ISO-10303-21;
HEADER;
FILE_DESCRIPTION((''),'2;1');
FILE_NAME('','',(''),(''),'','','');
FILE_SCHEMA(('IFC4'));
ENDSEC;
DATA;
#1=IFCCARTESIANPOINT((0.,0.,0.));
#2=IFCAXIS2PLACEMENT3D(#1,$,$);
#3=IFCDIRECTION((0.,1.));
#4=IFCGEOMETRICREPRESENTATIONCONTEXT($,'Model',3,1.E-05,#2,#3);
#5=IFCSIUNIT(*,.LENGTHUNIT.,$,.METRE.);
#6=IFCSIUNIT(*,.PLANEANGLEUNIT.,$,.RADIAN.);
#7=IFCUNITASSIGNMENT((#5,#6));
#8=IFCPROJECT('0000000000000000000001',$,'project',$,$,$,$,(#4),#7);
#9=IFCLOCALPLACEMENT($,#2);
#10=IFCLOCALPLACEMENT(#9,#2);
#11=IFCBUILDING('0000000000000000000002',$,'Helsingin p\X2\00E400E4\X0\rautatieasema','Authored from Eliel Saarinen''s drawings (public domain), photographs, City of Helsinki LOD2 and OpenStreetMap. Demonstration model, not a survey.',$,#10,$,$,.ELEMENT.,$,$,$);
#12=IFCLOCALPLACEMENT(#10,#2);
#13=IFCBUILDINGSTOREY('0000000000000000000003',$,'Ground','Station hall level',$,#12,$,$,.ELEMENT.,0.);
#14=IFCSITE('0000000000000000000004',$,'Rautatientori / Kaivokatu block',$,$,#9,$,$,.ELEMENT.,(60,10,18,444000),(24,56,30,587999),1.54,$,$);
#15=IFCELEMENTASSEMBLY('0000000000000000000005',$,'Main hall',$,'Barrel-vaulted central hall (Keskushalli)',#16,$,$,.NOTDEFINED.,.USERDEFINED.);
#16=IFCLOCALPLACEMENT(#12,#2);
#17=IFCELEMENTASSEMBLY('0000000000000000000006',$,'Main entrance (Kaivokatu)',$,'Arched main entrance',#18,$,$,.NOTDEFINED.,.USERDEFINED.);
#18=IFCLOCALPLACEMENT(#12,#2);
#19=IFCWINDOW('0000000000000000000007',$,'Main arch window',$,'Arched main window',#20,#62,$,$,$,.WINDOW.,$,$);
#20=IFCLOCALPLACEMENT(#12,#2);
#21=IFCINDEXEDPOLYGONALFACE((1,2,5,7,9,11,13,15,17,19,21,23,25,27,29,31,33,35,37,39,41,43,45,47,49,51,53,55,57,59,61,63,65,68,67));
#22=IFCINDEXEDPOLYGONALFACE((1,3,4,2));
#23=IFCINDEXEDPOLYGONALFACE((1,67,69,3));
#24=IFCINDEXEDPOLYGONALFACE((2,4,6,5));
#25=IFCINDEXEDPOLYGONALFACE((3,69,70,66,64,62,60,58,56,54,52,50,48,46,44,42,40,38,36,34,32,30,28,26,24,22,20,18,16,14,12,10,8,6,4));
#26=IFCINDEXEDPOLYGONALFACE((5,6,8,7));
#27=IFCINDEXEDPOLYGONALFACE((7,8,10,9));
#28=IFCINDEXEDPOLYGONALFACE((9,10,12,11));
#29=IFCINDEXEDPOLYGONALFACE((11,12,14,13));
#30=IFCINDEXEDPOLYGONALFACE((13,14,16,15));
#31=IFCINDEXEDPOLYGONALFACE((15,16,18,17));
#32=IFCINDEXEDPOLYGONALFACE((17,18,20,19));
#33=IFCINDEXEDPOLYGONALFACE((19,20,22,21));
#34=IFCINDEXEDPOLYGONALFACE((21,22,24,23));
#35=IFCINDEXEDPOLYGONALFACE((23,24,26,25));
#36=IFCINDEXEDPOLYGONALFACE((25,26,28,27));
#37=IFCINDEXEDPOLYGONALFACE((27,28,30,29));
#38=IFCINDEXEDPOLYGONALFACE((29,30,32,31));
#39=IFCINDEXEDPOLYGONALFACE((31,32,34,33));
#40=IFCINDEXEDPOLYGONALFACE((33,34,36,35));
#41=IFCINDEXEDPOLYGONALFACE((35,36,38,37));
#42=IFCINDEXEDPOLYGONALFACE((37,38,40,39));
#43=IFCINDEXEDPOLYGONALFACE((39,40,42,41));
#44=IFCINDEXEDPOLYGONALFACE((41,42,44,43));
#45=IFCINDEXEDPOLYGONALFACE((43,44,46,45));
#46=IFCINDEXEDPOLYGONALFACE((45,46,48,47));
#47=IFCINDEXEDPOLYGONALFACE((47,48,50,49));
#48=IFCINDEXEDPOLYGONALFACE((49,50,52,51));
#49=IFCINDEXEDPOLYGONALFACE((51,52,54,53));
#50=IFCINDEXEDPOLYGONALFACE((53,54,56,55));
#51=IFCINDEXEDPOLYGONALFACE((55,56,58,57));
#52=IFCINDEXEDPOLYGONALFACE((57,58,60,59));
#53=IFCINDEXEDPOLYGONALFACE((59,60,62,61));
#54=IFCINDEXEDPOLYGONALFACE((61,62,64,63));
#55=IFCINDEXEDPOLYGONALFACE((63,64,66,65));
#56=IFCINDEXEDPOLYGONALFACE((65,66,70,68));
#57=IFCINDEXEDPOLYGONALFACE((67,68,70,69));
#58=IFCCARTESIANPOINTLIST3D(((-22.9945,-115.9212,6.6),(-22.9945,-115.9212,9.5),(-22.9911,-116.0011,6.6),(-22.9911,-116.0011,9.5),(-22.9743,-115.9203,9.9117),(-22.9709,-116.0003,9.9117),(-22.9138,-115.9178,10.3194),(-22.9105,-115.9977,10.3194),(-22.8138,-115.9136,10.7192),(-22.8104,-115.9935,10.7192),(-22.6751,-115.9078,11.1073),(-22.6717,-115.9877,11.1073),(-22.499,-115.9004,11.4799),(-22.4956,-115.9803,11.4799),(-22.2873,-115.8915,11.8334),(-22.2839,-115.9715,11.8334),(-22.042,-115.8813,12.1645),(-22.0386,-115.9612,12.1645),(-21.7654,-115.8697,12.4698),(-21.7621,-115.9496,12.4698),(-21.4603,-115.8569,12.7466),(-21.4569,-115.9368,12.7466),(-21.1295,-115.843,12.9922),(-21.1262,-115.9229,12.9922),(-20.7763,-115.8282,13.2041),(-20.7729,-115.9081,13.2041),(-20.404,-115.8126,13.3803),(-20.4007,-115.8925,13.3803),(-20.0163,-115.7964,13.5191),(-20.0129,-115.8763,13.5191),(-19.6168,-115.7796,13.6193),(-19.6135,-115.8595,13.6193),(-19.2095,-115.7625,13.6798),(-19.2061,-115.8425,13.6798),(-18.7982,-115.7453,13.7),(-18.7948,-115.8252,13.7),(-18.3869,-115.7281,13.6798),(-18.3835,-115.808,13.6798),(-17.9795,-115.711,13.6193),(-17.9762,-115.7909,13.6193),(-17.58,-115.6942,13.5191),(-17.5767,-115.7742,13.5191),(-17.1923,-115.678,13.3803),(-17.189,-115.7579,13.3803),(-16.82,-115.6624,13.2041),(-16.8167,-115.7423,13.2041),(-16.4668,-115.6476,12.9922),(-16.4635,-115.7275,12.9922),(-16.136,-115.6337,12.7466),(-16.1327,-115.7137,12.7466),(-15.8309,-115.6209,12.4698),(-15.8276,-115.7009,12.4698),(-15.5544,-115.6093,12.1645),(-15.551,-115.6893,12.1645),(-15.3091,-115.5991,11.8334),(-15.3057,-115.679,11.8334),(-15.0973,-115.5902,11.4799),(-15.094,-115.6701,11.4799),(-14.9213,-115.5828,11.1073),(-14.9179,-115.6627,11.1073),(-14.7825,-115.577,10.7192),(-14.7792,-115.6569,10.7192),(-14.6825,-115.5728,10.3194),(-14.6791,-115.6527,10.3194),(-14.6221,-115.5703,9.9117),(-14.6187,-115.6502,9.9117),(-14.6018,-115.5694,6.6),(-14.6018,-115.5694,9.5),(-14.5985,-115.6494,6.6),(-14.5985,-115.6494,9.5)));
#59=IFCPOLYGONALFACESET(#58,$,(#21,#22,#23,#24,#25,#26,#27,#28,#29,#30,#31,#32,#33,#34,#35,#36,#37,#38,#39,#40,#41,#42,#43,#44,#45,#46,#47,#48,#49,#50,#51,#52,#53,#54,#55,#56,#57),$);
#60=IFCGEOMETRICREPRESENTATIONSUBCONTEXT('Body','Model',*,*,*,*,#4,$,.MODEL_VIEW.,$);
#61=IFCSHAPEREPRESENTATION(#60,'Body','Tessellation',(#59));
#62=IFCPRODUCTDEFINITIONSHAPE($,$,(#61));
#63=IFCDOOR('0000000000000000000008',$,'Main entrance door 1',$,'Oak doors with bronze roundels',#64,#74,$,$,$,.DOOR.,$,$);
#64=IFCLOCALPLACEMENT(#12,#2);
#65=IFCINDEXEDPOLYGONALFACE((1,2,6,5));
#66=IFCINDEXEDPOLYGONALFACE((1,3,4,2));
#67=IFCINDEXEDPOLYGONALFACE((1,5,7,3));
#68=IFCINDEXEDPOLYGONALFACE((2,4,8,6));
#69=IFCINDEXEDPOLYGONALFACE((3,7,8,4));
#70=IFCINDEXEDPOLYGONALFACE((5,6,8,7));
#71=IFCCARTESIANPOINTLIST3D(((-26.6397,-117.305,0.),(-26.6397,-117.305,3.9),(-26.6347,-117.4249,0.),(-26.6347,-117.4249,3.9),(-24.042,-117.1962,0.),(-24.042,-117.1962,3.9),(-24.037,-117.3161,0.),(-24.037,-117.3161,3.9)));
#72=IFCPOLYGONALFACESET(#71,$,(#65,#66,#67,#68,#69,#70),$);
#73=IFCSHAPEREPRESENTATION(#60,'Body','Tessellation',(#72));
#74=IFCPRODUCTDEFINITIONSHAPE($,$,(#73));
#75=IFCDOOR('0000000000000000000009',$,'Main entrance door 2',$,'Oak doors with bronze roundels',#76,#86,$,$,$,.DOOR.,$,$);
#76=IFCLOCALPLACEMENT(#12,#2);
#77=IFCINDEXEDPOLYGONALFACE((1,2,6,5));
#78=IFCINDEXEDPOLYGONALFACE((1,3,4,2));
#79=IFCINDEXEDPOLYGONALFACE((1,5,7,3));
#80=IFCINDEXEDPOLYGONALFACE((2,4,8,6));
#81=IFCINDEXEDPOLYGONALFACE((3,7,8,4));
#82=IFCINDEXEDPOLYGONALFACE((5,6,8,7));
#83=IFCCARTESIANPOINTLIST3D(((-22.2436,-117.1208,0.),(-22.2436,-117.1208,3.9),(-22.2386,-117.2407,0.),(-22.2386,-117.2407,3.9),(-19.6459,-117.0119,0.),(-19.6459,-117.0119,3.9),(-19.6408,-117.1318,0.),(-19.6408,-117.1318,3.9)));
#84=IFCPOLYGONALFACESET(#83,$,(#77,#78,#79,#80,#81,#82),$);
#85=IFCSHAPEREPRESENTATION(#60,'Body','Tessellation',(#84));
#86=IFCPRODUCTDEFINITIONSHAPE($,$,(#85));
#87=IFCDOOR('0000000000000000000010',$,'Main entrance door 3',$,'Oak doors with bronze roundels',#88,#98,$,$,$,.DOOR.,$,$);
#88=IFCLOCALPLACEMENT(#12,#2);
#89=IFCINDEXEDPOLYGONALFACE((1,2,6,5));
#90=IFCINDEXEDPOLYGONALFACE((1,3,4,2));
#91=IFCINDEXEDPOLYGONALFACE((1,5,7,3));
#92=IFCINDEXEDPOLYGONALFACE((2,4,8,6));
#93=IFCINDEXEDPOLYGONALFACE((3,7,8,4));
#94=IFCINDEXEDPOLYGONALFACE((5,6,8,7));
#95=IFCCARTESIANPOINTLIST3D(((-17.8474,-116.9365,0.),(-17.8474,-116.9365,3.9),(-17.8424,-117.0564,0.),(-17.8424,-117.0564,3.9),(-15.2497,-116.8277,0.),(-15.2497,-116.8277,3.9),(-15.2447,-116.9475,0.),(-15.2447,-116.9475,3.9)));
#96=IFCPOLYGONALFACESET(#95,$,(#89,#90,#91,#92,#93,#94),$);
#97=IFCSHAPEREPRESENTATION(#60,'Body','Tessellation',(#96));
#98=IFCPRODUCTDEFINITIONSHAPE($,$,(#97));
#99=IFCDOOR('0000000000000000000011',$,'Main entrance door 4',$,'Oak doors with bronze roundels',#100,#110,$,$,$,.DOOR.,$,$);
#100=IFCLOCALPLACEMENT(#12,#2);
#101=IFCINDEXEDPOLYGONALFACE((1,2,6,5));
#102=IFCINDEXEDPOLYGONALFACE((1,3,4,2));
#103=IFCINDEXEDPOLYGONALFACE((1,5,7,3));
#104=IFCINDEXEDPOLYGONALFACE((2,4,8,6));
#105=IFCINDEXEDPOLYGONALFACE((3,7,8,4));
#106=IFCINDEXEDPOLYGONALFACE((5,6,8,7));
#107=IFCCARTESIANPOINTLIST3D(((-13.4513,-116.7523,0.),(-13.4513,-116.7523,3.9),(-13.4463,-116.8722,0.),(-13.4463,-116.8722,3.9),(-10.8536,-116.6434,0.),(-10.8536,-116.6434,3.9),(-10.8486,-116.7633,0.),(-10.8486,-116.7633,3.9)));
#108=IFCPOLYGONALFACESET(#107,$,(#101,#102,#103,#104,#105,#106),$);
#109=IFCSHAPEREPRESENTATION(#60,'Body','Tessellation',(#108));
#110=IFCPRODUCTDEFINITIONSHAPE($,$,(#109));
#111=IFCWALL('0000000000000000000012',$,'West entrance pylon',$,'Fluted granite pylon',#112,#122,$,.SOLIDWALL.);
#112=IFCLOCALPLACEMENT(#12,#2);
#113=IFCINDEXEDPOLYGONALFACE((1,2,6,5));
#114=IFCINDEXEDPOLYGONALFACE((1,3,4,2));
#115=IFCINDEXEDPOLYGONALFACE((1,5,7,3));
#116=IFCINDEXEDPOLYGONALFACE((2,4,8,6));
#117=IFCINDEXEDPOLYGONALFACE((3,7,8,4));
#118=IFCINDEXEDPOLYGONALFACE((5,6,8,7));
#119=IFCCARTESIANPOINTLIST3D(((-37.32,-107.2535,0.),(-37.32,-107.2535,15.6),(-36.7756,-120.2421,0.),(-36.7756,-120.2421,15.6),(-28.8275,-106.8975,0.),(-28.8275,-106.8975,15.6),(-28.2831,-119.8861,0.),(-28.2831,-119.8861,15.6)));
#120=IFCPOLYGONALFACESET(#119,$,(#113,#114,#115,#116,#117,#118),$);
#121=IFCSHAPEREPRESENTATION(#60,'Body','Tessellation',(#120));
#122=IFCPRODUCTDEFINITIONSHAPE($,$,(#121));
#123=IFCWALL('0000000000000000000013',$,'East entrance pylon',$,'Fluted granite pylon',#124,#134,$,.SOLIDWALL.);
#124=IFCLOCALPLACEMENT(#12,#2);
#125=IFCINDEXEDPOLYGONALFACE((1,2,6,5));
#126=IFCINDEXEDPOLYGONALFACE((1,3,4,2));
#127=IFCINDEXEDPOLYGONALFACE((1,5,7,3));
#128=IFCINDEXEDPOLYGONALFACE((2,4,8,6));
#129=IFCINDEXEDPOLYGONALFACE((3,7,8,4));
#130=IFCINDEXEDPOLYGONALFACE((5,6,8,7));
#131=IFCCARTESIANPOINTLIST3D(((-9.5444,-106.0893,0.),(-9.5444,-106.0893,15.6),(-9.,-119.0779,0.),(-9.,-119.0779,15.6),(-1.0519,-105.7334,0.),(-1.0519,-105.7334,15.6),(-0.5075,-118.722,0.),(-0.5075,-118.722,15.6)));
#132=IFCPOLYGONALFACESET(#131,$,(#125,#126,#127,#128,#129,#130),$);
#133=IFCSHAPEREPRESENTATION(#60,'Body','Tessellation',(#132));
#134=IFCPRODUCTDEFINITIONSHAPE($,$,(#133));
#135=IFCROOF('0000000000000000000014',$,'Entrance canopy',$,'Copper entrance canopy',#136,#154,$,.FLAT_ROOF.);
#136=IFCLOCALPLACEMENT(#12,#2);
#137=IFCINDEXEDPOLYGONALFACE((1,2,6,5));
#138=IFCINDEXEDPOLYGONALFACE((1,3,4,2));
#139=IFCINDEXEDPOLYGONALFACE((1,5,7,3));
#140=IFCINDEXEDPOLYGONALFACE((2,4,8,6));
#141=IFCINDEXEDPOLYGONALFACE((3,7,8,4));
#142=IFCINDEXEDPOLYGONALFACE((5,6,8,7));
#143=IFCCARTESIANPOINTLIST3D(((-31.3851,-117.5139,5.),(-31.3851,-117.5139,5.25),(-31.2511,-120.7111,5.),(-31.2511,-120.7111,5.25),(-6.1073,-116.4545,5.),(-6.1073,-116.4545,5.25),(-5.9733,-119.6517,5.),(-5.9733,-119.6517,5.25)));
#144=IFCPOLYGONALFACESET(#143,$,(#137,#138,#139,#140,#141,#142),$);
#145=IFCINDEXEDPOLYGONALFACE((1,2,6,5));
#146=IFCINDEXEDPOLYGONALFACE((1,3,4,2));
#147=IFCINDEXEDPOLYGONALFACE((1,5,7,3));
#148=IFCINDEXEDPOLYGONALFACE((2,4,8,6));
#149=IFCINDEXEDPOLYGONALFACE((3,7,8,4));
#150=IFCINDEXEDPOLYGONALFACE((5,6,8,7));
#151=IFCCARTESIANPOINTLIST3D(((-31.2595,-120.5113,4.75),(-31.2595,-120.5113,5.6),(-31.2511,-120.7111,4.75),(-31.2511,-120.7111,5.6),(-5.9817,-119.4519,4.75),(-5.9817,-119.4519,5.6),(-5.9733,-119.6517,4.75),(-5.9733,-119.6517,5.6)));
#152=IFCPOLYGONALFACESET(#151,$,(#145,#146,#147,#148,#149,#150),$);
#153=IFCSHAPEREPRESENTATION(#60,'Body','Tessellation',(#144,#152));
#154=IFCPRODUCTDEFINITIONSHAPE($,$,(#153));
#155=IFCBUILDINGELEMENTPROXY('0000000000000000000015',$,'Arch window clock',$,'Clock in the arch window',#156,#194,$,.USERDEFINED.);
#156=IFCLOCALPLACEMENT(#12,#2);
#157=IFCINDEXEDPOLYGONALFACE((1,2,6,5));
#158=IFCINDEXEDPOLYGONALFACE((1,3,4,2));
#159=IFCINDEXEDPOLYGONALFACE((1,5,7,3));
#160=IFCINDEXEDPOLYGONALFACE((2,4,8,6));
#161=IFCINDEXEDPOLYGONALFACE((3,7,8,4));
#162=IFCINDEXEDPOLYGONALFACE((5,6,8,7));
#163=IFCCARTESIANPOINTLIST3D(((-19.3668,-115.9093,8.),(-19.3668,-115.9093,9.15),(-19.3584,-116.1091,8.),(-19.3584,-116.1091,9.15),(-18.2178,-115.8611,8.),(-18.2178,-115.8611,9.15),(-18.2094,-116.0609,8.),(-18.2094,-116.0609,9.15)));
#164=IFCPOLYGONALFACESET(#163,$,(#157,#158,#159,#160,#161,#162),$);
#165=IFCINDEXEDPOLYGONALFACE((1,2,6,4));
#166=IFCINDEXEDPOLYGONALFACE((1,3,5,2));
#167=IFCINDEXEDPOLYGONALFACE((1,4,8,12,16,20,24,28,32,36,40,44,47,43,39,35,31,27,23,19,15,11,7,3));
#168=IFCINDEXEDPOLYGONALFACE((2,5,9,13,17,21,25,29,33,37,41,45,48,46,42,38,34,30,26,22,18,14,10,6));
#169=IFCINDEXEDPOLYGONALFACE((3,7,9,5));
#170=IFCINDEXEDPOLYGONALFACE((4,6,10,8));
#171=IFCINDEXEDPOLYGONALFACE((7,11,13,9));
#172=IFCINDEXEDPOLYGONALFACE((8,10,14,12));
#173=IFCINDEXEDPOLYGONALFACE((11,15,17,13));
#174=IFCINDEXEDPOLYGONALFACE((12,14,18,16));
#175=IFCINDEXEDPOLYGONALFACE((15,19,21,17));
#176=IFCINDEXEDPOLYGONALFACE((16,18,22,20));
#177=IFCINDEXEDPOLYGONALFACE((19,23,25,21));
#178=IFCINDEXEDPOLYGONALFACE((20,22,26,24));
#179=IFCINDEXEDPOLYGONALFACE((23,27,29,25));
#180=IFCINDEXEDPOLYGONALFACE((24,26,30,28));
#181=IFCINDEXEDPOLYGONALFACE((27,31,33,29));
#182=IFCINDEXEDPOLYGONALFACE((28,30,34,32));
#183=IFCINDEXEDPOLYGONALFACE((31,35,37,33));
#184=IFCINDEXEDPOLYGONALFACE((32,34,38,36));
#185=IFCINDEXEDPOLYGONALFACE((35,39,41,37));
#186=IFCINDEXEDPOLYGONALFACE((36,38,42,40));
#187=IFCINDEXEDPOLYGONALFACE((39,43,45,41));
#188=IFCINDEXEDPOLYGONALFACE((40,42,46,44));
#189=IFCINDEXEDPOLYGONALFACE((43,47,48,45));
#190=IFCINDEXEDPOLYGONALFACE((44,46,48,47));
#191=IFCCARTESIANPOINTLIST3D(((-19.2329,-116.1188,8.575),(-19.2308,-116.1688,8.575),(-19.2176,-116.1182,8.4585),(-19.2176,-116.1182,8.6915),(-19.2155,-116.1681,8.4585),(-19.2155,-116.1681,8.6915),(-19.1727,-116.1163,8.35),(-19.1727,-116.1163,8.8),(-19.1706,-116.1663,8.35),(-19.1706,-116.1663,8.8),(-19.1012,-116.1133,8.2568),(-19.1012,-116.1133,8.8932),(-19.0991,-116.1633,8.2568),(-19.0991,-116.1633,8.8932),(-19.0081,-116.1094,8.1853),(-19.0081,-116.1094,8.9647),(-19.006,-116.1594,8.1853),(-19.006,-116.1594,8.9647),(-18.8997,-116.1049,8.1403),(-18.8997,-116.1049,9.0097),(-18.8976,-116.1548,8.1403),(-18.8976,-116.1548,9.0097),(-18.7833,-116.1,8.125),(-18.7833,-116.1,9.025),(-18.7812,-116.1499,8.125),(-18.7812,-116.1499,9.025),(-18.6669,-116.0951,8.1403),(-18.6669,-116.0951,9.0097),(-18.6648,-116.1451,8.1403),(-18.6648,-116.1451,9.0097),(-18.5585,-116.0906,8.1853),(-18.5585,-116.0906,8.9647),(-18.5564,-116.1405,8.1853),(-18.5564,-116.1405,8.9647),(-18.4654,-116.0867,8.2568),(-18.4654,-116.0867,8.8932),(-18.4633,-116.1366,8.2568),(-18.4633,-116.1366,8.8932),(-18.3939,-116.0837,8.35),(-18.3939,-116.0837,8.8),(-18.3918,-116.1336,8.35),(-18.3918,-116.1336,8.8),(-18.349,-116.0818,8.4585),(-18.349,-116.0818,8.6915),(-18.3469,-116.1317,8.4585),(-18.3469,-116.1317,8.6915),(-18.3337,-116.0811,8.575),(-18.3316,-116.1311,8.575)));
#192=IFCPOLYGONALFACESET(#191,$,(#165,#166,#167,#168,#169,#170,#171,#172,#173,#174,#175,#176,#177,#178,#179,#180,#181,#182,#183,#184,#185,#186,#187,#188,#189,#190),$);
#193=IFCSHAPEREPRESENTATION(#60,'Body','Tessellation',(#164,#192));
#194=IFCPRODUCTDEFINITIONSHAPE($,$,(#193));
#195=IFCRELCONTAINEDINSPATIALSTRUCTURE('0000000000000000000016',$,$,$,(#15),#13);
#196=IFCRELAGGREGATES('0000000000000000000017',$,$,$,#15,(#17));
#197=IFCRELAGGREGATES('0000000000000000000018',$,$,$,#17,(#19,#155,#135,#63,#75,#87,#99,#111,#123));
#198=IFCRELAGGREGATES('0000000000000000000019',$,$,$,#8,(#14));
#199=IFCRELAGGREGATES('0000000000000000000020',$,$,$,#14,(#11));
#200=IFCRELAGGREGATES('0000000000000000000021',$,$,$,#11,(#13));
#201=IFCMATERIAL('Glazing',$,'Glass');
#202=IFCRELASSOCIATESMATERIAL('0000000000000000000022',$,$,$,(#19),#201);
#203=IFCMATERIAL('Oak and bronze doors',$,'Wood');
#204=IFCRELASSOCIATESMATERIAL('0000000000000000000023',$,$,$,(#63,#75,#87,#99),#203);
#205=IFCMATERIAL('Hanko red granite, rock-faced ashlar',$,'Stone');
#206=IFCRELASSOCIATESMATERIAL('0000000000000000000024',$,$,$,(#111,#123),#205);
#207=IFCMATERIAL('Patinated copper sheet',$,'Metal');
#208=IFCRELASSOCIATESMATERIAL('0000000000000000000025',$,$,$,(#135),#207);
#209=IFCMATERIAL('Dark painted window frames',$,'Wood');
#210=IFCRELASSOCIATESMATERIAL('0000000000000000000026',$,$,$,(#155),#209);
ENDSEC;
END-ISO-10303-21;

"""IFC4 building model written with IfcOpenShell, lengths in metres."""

from ifc_helpers import new_model, si_unit, direction, frame, frame_2d, origin, place, context, subcontext, project, spatial, polyline, rectangle, outline, extrude, material, element, aggregate, save


model = new_model("IFC4")

# Units and contexts
model_context = context("Model", 3, precision=1e-05, world=origin(), true_north=direction((0.0, 1.0)))
body_context = subcontext(model_context, "Body", "Model", "MODEL_VIEW")
ifc_project = project(units=[si_unit("LENGTHUNIT", "METRE"), si_unit("PLANEANGLEUNIT", "RADIAN")], contexts=[model_context])

# Site, building, storey
site_placement = place(None, origin())
site = spatial("IfcSite", under=ifc_project, at=site_placement, Name="Rautatientori / Kaivokatu block", CompositionType="ELEMENT", RefLatitude=(60, 10, 18, 444000), RefLongitude=(24, 56, 30, 587999), RefElevation=1.54)
building_placement = place(site_placement, origin())
building = spatial("IfcBuilding", under=site, at=building_placement, Name="Helsingin päärautatieasema", Description="Authored from Eliel Saarinen's drawings (public domain), photographs, City of Helsinki LOD2 and OpenStreetMap. Demonstration model, not a survey.", CompositionType="ELEMENT")
storey_placement = place(building_placement, origin())
storey = spatial("IfcBuildingStorey", under=building, at=storey_placement, Name="Ground", Description="Station hall level", CompositionType="ELEMENT", Elevation=0.0)

# Element assemblies, window, doors, walls, roof, building element proxy
assembly_1_placement = place(building_placement, origin())
assembly_1 = element("IfcElementAssembly", 1, at=assembly_1_placement, inside=storey, Name="Main hall", ObjectType="Barrel-vaulted central hall (Keskushalli)", AssemblyPlace="NOTDEFINED", PredefinedType="USERDEFINED")
assembly_2_placement = place(building_placement, origin())
assembly_2 = element("IfcElementAssembly", 2, at=assembly_2_placement, Name="Main entrance (Kaivokatu)", ObjectType="Arched main entrance", AssemblyPlace="NOTDEFINED", PredefinedType="USERDEFINED")
ifc_material_1 = material(Name="Patinated copper sheet", Category="Metal")
ifc_material_2 = material(Name="Hanko red granite, rock-faced ashlar", Category="Stone")
ifc_material_3 = material(Name="Glazing", Category="Glass")
window_placement = place(building_placement, origin())
window = element("IfcWindow", 3, at=window_placement, material=ifc_material_3, Name="Main arch window", ObjectType="Arched main window", PredefinedType="WINDOW", context=body_context, shape_type="SweptSolid", body=[
    extrude(outline(polyline([(-4.2, 6.6), (4.2, 6.6), (4.2, 9.5), (4.1798, 9.9117), (4.1193, 10.3194), (4.0191, 10.7192), (3.8803, 11.1073), (3.7041, 11.4799), (3.4922, 11.8334), (3.2466, 12.1645), (2.9698, 12.4698), (2.6645, 12.7466), (2.3334, 12.9922), (1.9799, 13.2041), (1.6073, 13.3803), (1.2192, 13.5191), (0.8194, 13.6193), (0.4117, 13.6798), (0.0, 13.7), (-0.4117, 13.6798), (-0.8194, 13.6193), (-1.2192, 13.5191), (-1.6073, 13.3803), (-1.9799, 13.2041), (-2.3334, 12.9922), (-2.6645, 12.7466), (-2.9698, 12.4698), (-3.2466, 12.1645), (-3.4922, 11.8334), (-3.7041, 11.4799), (-3.8803, 11.1073), (-4.0191, 10.7192), (-4.1193, 10.3194), (-4.1798, 9.9117), (-4.2, 9.5), (-4.2, 6.6)])), frame((-18.7982, -115.7453, 0.0), z_axis=(0.041876, -0.999123, 0.0), x_axis=(0.999123, 0.041876, 0.0)), (0.0, 0.0, 1.0), 0.08),
])
ifc_material_4 = material(Name="Oak and bronze doors", Category="Wood")
door_1_placement = place(building_placement, origin())
door_1 = element("IfcDoor", 4, at=door_1_placement, material=ifc_material_4, Name="Main entrance door 1", ObjectType="Oak doors with bronze roundels", PredefinedType="DOOR", context=body_context, shape_type="SweptSolid", body=[
    extrude(rectangle(XDim=2.6, YDim=0.12, at=frame_2d((0.0, 0.0), x_axis=(0.999123, 0.041876))), frame((-25.3384, -117.3105, 0.0)), (0.0, 0.0, 1.0), 3.9),
])
door_2_placement = place(building_placement, origin())
door_2 = element("IfcDoor", 5, at=door_2_placement, material=ifc_material_4, Name="Main entrance door 2", ObjectType="Oak doors with bronze roundels", PredefinedType="DOOR", context=body_context, shape_type="SweptSolid", body=[
    extrude(rectangle(XDim=2.6, YDim=0.12, at=frame_2d((0.0, 0.0), x_axis=(0.999123, 0.041876))), frame((-20.9422, -117.1263, 0.0)), (0.0, 0.0, 1.0), 3.9),
])
door_3_placement = place(building_placement, origin())
door_3 = element("IfcDoor", 6, at=door_3_placement, material=ifc_material_4, Name="Main entrance door 3", ObjectType="Oak doors with bronze roundels", PredefinedType="DOOR", context=body_context, shape_type="SweptSolid", body=[
    extrude(rectangle(XDim=2.6, YDim=0.12, at=frame_2d((0.0, 0.0), x_axis=(0.999123, 0.041876))), frame((-16.5461, -116.942, 0.0)), (0.0, 0.0, 1.0), 3.9),
])
door_4_placement = place(building_placement, origin())
door_4 = element("IfcDoor", 7, at=door_4_placement, material=ifc_material_4, Name="Main entrance door 4", ObjectType="Oak doors with bronze roundels", PredefinedType="DOOR", context=body_context, shape_type="SweptSolid", body=[
    extrude(rectangle(XDim=2.6, YDim=0.12, at=frame_2d((0.0, 0.0), x_axis=(0.999123, 0.041876))), frame((-12.1499, -116.7578, 0.0)), (0.0, 0.0, 1.0), 3.9),
])
wall_1_placement = place(building_placement, origin())
wall_1 = element("IfcWall", 8, at=wall_1_placement, material=ifc_material_2, Name="West entrance pylon", ObjectType="Fluted granite pylon", PredefinedType="SOLIDWALL", context=body_context, shape_type="SweptSolid", body=[
    extrude(rectangle(XDim=8.5, YDim=13.0, at=frame_2d((0.0, 0.0), x_axis=(0.999123, 0.041876))), frame((-32.8015, -113.5698, 0.0)), (0.0, 0.0, 1.0), 15.6),
])
wall_2_placement = place(building_placement, origin())
wall_2 = element("IfcWall", 9, at=wall_2_placement, material=ifc_material_2, Name="East entrance pylon", ObjectType="Fluted granite pylon", PredefinedType="SOLIDWALL", context=body_context, shape_type="SweptSolid", body=[
    extrude(rectangle(XDim=8.5, YDim=13.0, at=frame_2d((0.0, 0.0), x_axis=(0.999123, 0.041876))), frame((-5.0259, -112.4056, 0.0)), (0.0, 0.0, 1.0), 15.6),
])
aggregate(assembly_1, [assembly_2])
roof_1_placement = place(building_placement, origin())
roof_1 = element("IfcRoof", 10, at=roof_1_placement, material=ifc_material_1, Name="Entrance canopy", ObjectType="Copper entrance canopy", PredefinedType="FLAT_ROOF", context=body_context, shape_type="SweptSolid", body=[
    extrude(rectangle(XDim=25.3, YDim=3.2, at=frame_2d((0.0, 0.0), x_axis=(0.999123, 0.041876))), frame((-18.6792, -118.5828, 5.0)), (0.0, 0.0, 1.0), 0.25),
    extrude(rectangle(XDim=25.3, YDim=0.2, at=frame_2d((0.0, 0.0), x_axis=(0.999123, 0.041876))), frame((-18.6164, -120.0815, 4.75)), (0.0, 0.0, 1.0), 0.85),
])
ifc_material_5 = material(Name="Dark painted window frames", Category="Wood")
proxy_1_placement = place(building_placement, origin())
proxy_1 = element("IfcBuildingElementProxy", 11, at=proxy_1_placement, material=ifc_material_5, Name="Arch window clock", ObjectType="Clock in the arch window", PredefinedType="USERDEFINED", context=body_context, shape_type="SweptSolid", body=[
    extrude(rectangle(XDim=1.15, YDim=0.2, at=frame_2d((0.0, 0.0), x_axis=(0.999123, 0.041876))), frame((-18.7881, -115.9851, 8.0)), (0.0, 0.0, 1.0), 1.15),
    extrude(outline(polyline([(0.45, 0.0), (0.4347, 0.1165), (0.3897, 0.225), (0.3182, 0.3182), (0.225, 0.3897), (0.1165, 0.4347), (0.0, 0.45), (-0.1165, 0.4347), (-0.225, 0.3897), (-0.3182, 0.3182), (-0.3897, 0.225), (-0.4347, 0.1165), (-0.45, 0.0), (-0.4347, -0.1165), (-0.3897, -0.225), (-0.3182, -0.3182), (-0.225, -0.3897), (-0.1165, -0.4347), (0.0, -0.45), (0.1165, -0.4347), (0.225, -0.3897), (0.3182, -0.3182), (0.3897, -0.225), (0.4347, -0.1165), (0.45, 0.0), (0.45, 0.0)])), frame((-18.7833, -116.1, 8.575), z_axis=(0.041876, -0.999123, 0.0), x_axis=(0.999123, 0.041876, 0.0)), (0.0, 0.0, 1.0), 0.05),
])
aggregate(assembly_2, [window, proxy_1, roof_1, door_1, door_2, door_3, door_4, wall_1, wall_2])

save(model, "model.ifc")
